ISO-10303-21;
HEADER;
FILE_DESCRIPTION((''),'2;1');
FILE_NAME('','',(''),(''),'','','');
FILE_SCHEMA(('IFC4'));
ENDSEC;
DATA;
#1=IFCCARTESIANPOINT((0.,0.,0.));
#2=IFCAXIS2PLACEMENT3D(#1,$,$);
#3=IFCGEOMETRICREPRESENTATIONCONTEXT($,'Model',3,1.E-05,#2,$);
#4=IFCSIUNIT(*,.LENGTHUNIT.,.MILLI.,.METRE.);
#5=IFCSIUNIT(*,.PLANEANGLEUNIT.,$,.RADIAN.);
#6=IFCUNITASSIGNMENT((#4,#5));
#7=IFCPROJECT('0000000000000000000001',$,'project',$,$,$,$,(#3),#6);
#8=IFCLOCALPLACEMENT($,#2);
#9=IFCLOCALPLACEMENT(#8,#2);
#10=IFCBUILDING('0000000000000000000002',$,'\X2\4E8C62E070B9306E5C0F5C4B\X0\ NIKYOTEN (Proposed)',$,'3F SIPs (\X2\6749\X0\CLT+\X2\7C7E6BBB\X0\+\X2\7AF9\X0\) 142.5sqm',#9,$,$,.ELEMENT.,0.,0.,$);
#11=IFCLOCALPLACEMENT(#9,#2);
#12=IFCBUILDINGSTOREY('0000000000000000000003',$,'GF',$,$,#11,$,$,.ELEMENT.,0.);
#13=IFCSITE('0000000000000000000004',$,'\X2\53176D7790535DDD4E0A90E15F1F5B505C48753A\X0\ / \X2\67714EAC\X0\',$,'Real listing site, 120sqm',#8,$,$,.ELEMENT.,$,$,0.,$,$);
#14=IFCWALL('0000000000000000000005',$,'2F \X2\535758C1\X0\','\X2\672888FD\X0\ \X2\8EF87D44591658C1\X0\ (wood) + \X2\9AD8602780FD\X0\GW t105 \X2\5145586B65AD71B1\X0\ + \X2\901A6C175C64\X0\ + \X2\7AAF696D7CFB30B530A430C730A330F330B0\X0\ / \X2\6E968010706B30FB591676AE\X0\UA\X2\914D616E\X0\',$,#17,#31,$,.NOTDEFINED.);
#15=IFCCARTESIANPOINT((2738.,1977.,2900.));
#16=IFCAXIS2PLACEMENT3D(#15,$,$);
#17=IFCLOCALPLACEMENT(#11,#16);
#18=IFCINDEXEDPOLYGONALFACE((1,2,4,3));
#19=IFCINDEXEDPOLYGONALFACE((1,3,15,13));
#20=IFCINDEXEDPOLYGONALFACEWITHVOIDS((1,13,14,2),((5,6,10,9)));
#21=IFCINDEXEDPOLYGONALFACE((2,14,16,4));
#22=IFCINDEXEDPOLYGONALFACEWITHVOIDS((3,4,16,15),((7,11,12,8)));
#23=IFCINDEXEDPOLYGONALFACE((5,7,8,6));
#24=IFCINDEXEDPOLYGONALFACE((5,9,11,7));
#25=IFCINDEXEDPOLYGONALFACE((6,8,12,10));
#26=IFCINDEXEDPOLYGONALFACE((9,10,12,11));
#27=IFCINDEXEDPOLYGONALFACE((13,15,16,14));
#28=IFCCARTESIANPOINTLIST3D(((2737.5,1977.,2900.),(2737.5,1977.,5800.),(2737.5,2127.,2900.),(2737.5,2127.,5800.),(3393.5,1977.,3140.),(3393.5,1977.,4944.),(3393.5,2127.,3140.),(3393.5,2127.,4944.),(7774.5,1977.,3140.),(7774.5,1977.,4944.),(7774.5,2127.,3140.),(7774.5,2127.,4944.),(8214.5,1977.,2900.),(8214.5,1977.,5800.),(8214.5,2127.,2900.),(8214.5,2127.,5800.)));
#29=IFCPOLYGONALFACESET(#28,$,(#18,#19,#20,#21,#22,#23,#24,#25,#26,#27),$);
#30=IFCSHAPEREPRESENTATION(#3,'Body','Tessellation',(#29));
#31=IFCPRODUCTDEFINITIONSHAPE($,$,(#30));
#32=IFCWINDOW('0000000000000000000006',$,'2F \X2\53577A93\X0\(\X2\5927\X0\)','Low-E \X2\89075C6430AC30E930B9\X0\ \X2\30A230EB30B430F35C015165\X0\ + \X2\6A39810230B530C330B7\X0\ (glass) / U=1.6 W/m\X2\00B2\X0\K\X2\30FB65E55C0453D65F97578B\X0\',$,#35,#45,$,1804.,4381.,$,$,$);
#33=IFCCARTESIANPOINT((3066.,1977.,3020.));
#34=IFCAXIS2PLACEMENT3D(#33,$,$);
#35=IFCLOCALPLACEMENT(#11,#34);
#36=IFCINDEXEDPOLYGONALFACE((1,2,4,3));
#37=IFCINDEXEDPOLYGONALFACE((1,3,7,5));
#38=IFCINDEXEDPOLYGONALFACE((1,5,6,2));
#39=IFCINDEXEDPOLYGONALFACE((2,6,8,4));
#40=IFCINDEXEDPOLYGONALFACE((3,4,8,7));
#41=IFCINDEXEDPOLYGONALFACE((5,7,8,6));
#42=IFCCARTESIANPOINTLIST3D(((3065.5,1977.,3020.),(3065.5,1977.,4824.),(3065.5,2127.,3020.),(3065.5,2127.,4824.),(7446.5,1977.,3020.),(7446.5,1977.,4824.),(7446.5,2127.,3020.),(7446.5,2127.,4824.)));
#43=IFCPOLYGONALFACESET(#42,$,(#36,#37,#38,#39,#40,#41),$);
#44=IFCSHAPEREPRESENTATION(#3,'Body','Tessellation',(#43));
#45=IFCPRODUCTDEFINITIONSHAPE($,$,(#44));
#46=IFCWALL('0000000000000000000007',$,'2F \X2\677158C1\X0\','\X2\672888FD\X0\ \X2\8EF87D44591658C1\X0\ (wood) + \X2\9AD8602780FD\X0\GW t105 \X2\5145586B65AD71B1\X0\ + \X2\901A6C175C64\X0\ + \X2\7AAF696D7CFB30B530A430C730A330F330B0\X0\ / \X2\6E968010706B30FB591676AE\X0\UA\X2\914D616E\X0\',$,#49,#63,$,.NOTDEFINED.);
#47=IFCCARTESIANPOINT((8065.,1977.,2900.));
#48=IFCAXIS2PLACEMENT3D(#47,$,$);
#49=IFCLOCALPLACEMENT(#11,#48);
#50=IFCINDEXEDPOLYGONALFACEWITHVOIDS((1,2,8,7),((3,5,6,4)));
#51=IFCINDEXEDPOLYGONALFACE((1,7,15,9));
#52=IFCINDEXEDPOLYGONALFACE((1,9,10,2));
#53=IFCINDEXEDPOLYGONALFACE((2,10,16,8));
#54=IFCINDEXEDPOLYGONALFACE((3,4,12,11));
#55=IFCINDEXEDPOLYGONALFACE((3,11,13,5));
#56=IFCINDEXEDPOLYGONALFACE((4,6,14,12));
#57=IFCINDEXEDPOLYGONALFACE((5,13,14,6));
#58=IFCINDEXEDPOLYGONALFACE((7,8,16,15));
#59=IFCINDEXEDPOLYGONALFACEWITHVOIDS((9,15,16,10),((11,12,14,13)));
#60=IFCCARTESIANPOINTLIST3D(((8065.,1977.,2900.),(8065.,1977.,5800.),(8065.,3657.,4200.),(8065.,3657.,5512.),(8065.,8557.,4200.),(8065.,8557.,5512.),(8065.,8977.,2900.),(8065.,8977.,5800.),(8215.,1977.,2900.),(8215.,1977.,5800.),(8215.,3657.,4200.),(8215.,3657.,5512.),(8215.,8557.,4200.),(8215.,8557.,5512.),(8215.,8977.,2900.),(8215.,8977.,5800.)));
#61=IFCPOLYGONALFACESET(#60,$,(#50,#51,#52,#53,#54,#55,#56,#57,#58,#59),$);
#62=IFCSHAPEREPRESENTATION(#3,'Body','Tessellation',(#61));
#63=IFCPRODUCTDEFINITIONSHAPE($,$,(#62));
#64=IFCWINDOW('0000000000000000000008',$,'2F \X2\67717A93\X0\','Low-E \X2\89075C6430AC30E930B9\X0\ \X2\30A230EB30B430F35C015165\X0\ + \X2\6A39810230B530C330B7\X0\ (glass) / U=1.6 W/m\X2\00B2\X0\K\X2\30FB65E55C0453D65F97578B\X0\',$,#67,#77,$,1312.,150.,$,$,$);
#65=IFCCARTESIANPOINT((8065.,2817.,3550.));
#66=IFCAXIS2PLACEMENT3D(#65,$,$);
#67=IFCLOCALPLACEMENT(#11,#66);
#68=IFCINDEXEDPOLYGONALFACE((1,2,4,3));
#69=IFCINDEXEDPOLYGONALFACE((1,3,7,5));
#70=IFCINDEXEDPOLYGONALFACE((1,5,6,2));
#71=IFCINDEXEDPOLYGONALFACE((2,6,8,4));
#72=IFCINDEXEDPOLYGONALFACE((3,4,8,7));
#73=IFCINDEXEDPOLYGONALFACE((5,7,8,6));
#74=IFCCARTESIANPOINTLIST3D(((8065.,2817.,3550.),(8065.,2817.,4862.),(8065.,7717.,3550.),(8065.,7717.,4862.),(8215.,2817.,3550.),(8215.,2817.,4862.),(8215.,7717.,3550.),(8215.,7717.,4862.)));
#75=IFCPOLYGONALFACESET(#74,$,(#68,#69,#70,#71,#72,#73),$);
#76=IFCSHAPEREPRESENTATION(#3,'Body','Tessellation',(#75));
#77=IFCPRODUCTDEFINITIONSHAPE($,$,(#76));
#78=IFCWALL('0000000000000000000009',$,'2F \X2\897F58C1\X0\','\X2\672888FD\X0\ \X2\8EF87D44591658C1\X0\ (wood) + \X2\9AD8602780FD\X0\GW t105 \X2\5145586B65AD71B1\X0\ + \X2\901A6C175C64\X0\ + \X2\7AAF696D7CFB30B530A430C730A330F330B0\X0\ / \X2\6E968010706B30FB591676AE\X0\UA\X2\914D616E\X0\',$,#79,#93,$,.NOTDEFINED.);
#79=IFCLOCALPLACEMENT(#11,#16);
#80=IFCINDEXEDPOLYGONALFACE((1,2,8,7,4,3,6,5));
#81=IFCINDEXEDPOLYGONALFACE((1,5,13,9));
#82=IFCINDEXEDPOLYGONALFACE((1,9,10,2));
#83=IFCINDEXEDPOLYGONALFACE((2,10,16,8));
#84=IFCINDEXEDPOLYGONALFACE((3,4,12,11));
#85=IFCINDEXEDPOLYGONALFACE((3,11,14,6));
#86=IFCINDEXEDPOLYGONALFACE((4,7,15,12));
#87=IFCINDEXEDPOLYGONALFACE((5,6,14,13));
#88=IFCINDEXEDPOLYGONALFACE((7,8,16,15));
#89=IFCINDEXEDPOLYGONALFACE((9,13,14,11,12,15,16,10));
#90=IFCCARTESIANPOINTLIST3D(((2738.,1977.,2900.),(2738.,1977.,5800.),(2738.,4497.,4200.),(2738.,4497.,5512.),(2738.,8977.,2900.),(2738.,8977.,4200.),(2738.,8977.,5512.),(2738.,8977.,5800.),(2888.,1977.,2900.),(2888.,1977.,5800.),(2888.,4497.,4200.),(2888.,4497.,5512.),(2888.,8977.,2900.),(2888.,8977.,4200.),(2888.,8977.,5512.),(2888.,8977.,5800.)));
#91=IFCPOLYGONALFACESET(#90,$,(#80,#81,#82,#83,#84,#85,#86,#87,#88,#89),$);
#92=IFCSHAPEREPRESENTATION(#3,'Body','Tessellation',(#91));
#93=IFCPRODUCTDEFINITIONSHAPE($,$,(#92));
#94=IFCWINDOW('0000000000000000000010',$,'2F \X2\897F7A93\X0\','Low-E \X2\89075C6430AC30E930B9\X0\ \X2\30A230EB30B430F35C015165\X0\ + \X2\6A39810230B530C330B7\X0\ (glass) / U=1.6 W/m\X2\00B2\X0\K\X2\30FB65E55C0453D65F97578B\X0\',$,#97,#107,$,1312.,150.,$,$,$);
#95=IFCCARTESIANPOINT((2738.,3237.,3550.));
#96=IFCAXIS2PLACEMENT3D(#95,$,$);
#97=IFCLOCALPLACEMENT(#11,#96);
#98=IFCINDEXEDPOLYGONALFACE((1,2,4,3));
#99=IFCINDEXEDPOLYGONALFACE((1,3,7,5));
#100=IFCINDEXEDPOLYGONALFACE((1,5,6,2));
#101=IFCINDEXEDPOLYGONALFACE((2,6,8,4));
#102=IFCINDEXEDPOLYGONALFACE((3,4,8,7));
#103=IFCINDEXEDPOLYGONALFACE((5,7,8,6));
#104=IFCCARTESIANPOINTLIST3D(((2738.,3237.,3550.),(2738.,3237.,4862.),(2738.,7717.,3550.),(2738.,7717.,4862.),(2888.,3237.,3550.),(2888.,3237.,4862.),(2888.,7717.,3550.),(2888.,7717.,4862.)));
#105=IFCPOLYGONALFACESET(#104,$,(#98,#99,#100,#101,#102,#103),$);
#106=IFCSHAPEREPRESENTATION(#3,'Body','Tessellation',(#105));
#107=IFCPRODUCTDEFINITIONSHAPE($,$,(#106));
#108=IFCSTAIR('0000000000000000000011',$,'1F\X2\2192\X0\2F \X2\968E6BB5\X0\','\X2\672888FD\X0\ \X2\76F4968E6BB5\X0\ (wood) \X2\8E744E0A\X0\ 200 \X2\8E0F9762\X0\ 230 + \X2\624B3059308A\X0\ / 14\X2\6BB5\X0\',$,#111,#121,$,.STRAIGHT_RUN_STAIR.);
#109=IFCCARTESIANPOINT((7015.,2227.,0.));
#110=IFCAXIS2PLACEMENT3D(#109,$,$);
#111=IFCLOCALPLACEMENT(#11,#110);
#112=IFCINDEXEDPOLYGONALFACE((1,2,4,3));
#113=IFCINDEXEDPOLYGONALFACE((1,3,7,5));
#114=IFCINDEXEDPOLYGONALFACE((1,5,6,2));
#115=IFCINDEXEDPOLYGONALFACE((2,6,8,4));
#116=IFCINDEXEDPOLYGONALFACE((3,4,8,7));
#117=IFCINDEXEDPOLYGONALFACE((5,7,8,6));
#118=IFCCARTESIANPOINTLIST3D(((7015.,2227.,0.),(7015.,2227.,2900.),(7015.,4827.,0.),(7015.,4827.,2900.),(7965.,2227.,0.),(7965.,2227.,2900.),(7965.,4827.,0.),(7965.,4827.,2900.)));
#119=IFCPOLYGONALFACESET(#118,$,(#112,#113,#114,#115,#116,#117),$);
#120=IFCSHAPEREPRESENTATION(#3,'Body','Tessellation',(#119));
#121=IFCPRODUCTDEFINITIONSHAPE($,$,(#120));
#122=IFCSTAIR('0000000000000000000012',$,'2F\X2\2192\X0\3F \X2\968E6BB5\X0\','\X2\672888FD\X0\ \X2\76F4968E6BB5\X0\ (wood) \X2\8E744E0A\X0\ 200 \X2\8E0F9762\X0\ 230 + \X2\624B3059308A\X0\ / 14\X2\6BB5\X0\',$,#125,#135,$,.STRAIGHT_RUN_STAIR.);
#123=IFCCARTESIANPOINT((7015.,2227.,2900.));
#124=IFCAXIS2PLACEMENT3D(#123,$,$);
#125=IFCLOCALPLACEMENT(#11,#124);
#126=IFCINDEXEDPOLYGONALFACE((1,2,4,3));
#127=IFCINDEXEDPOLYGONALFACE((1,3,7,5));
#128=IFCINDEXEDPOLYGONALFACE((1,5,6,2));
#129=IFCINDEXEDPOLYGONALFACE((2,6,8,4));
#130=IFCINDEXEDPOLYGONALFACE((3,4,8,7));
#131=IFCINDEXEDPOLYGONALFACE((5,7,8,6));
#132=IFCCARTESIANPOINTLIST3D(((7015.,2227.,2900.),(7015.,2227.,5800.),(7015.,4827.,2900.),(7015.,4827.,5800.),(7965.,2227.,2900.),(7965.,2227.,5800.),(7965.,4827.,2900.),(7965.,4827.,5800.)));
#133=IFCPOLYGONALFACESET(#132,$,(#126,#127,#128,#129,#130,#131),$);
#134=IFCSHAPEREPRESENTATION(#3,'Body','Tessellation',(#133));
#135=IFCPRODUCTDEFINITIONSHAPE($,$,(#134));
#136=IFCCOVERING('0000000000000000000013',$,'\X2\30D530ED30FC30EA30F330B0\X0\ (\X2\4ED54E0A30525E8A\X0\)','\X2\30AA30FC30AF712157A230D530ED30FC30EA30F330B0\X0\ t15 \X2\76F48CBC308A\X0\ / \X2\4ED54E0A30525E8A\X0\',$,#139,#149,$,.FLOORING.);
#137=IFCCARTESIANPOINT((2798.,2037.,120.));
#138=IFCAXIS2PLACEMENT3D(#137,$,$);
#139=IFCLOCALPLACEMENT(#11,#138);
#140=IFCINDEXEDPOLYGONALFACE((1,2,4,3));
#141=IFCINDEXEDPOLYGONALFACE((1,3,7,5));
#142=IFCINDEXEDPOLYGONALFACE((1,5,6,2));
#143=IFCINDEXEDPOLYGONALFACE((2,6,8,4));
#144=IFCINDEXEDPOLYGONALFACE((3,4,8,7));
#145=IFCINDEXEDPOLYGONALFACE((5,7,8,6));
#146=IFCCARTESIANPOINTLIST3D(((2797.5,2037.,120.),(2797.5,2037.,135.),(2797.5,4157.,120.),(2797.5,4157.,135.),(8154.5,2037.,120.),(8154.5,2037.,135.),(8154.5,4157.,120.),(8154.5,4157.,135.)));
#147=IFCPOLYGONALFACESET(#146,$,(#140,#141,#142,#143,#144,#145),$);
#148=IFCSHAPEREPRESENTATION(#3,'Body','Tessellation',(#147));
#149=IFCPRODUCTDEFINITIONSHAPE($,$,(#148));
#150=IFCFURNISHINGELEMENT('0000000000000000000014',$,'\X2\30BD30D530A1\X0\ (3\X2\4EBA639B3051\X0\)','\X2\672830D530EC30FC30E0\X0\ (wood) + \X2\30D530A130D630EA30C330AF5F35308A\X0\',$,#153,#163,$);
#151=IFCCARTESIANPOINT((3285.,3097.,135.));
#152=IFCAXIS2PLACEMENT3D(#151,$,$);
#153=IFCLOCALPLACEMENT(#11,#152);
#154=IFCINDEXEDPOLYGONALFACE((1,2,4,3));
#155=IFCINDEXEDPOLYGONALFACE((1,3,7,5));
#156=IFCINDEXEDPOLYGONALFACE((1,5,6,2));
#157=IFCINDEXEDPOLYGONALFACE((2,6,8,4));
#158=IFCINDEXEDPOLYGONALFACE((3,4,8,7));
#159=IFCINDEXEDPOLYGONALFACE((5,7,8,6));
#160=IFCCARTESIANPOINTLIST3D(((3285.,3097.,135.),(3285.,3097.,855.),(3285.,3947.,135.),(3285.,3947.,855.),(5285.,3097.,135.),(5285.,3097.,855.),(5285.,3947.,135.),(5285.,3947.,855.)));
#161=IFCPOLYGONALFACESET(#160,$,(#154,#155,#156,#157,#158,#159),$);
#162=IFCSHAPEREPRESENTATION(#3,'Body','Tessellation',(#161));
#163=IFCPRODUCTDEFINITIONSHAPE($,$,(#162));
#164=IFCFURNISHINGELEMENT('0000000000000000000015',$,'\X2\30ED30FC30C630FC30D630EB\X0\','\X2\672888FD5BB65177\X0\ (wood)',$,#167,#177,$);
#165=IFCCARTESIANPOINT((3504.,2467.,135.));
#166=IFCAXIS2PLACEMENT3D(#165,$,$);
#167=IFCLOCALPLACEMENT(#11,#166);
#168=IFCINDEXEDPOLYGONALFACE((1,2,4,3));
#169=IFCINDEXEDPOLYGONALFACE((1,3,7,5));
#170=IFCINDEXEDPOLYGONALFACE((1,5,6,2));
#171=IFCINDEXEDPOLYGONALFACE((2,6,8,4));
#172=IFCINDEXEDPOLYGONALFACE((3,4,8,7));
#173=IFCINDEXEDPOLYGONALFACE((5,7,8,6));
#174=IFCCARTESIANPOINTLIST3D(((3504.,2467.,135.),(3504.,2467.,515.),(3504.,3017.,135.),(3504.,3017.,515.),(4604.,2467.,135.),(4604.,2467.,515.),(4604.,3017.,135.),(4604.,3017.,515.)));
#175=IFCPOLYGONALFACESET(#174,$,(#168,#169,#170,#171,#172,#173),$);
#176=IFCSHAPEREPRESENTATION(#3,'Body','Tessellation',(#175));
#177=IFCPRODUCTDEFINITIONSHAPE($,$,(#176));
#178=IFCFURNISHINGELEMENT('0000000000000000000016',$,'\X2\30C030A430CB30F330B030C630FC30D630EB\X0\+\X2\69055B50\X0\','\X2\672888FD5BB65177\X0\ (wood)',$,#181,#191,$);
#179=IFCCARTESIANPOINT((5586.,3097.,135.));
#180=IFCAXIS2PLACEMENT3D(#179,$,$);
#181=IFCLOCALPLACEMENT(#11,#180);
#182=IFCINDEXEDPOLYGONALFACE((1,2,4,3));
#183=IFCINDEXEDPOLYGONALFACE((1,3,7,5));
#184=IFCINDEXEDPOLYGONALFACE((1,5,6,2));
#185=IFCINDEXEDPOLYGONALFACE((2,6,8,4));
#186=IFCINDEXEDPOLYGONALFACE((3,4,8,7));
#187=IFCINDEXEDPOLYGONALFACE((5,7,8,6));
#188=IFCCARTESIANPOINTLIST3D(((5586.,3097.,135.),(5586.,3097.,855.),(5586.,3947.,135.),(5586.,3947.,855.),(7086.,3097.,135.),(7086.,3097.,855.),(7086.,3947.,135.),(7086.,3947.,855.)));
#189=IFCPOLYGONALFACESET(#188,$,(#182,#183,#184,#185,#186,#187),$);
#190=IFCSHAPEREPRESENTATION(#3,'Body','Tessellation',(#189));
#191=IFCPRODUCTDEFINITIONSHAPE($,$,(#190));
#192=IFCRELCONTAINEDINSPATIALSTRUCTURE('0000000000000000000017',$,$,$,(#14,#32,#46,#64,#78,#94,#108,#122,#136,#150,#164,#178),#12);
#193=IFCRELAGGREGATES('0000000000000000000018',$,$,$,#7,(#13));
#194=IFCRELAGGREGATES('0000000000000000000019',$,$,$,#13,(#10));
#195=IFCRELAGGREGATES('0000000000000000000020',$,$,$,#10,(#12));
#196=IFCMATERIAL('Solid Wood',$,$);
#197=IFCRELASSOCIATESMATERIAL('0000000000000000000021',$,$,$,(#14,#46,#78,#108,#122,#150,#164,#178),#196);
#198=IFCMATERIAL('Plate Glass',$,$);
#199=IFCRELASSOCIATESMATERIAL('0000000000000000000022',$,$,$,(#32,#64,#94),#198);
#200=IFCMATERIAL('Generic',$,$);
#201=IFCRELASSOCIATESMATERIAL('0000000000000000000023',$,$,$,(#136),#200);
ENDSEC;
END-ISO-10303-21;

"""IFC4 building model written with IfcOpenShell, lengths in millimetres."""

from ifc_helpers import new_model, si_unit, frame, frame_2d, origin, place, context, project, spatial, rectangle, extrude, material, element, fill, save


model = new_model("IFC4")

# Units and contexts
model_context = context("Model", 3, precision=1e-05, world=origin())
ifc_project = project(units=[si_unit("LENGTHUNIT", "METRE", prefix="MILLI"), si_unit("PLANEANGLEUNIT", "RADIAN")], contexts=[model_context])

# Site, building, storey
site_placement = place(None, origin())
site = spatial("IfcSite", under=ifc_project, at=site_placement, Name="北海道川上郡弟子屈町 / 東京", ObjectType="Real listing site, 120sqm", CompositionType="ELEMENT", RefElevation=0.0)
building_placement = place(site_placement, origin())
building = spatial("IfcBuilding", under=site, at=building_placement, Name="二拠点の小屋 NIKYOTEN (Proposed)", ObjectType="3F SIPs (杉CLT+籾殻+竹) 142.5sqm", CompositionType="ELEMENT", ElevationOfRefHeight=0.0, ElevationOfTerrain=0.0)
storey_placement = place(building_placement, origin())
storey = spatial("IfcBuildingStorey", under=building, at=storey_placement, Name="GF", CompositionType="ELEMENT", Elevation=0.0)

# Shared definitions
ifc_material_1 = material(Name="Solid Wood")

# Shared definitions
ifc_material_2 = material(Name="Plate Glass")

# Walls, openings, windows
wall_1_placement = place(storey_placement, frame((2738.0, 1977.0, 2900.0)))
wall_1 = element("IfcWall", 1, at=wall_1_placement, inside=storey, material=ifc_material_1, Name="2F 南壁", Description="木製 軸組外壁 (wood) + 高性能GW t105 充填断熱 + 通気層 + 窯業系サイディング / 準耐火・外皮UA配慮", PredefinedType="NOTDEFINED", context=model_context, shape_type="SweptSolid", body=[
    extrude(rectangle(XDim=5477.0, YDim=150.0, at=frame_2d((2738.0, 75.0))), frame((2738.0, 1977.0, 2900.0)), (0.0, 0.0, 1.0), 2900.0),
])
opening_1_placement = place(storey_placement, frame((3066.0, 1977.0, 3020.0)))
opening_1 = element("IfcOpeningElement", 2, at=opening_1_placement, cuts=wall_1, PredefinedType="NOTDEFINED", context=model_context, shape_type="SweptSolid", body=[
    extrude(rectangle(XDim=4381.0, YDim=150.0, at=frame_2d((2190.0, 75.0))), frame((3066.0, 1977.0, 3020.0)), (0.0, 0.0, 1.0), 1804.0),
])
window_1_placement = place(storey_placement, frame((3066.0, 1977.0, 3020.0)))
window_1 = element("IfcWindow", 3, at=window_1_placement, inside=storey, material=ifc_material_2, Name="2F 南窓(大)", Description="Low-E 複層ガラス アルゴン封入 + 樹脂サッシ (glass) / U=1.6 W/m²K・日射取得型", OverallHeight=1804.0, OverallWidth=4381.0, context=model_context, shape_type="SweptSolid", body=[
    extrude(rectangle(XDim=4381.0, YDim=150.0, at=frame_2d((2190.0, 75.0))), frame((3066.0, 1977.0, 3020.0)), (0.0, 0.0, 1.0), 1804.0),
])
fill(opening_1, window_1)
wall_2_placement = place(storey_placement, frame((8065.0, 1977.0, 2900.0)))
wall_2 = element("IfcWall", 4, at=wall_2_placement, inside=storey, material=ifc_material_1, Name="2F 東壁", Description="木製 軸組外壁 (wood) + 高性能GW t105 充填断熱 + 通気層 + 窯業系サイディング / 準耐火・外皮UA配慮", PredefinedType="NOTDEFINED", context=model_context, shape_type="SweptSolid", body=[
    extrude(rectangle(XDim=150.0, YDim=7000.0, at=frame_2d((75.0, 3500.0))), frame((8065.0, 1977.0, 2900.0)), (0.0, 0.0, 1.0), 2900.0),
])
opening_2_placement = place(storey_placement, frame((8065.0, 2817.0, 3550.0)))
opening_2 = element("IfcOpeningElement", 5, at=opening_2_placement, cuts=wall_2, PredefinedType="NOTDEFINED", context=model_context, shape_type="SweptSolid", body=[
    extrude(rectangle(XDim=150.0, YDim=4900.0, at=frame_2d((75.0, 2450.0))), frame((8065.0, 2817.0, 3550.0)), (0.0, 0.0, 1.0), 1312.0),
])
window_2_placement = place(storey_placement, frame((8065.0, 2817.0, 3550.0)))
window_2 = element("IfcWindow", 6, at=window_2_placement, inside=storey, material=ifc_material_2, Name="2F 東窓", Description="Low-E 複層ガラス アルゴン封入 + 樹脂サッシ (glass) / U=1.6 W/m²K・日射取得型", OverallHeight=1312.0, OverallWidth=150.0, context=model_context, shape_type="SweptSolid", body=[
    extrude(rectangle(XDim=150.0, YDim=4900.0, at=frame_2d((75.0, 2450.0))), frame((8065.0, 2817.0, 3550.0)), (0.0, 0.0, 1.0), 1312.0),
])
fill(opening_2, window_2)
wall_3_placement = place(storey_placement, frame((2738.0, 1977.0, 2900.0)))
wall_3 = element("IfcWall", 7, at=wall_3_placement, inside=storey, material=ifc_material_1, Name="2F 西壁", Description="木製 軸組外壁 (wood) + 高性能GW t105 充填断熱 + 通気層 + 窯業系サイディング / 準耐火・外皮UA配慮", PredefinedType="NOTDEFINED", context=model_context, shape_type="SweptSolid", body=[
    extrude(rectangle(XDim=150.0, YDim=7000.0, at=frame_2d((75.0, 3500.0))), frame((2738.0, 1977.0, 2900.0)), (0.0, 0.0, 1.0), 2900.0),
])
opening_3_placement = place(storey_placement, frame((2738.0, 3237.0, 3550.0)))
opening_3 = element("IfcOpeningElement", 8, at=opening_3_placement, cuts=wall_3, PredefinedType="NOTDEFINED", context=model_context, shape_type="SweptSolid", body=[
    extrude(rectangle(XDim=150.0, YDim=4480.0, at=frame_2d((75.0, 2240.0))), frame((2738.0, 3237.0, 3550.0)), (0.0, 0.0, 1.0), 1312.0),
])
window_3_placement = place(storey_placement, frame((2738.0, 3237.0, 3550.0)))
window_3 = element("IfcWindow", 9, at=window_3_placement, inside=storey, material=ifc_material_2, Name="2F 西窓", Description="Low-E 複層ガラス アルゴン封入 + 樹脂サッシ (glass) / U=1.6 W/m²K・日射取得型", OverallHeight=1312.0, OverallWidth=150.0, context=model_context, shape_type="SweptSolid", body=[
    extrude(rectangle(XDim=150.0, YDim=4480.0, at=frame_2d((75.0, 2240.0))), frame((2738.0, 3237.0, 3550.0)), (0.0, 0.0, 1.0), 1312.0),
])
fill(opening_3, window_3)

# Stairs
stair_1_placement = place(storey_placement, frame((7015.0, 2227.0, 0.0)))
element("IfcStair", 10, at=stair_1_placement, inside=storey, material=ifc_material_1, Name="1F→2F 階段", Description="木製 直階段 (wood) 蹴上 200 踏面 230 + 手すり / 14段", PredefinedType="STRAIGHT_RUN_STAIR", context=model_context, shape_type="SweptSolid", body=[
    extrude(rectangle(XDim=950.0, YDim=2600.0, at=frame_2d((475.0, 1300.0))), frame((7015.0, 2227.0, 0.0)), (0.0, 0.0, 1.0), 2900.0),
])
stair_2_placement = place(storey_placement, frame((7015.0, 2227.0, 2900.0)))
element("IfcStair", 11, at=stair_2_placement, inside=storey, material=ifc_material_1, Name="2F→3F 階段", Description="木製 直階段 (wood) 蹴上 200 踏面 230 + 手すり / 14段", PredefinedType="STRAIGHT_RUN_STAIR", context=model_context, shape_type="SweptSolid", body=[
    extrude(rectangle(XDim=950.0, YDim=2600.0, at=frame_2d((475.0, 1300.0))), frame((7015.0, 2227.0, 2900.0)), (0.0, 0.0, 1.0), 2900.0),
])

# Covering
ifc_material_3 = material(Name="Generic")
covering_placement = place(storey_placement, frame((2798.0, 2037.0, 120.0)))
element("IfcCovering", 12, at=covering_placement, inside=storey, material=ifc_material_3, Name="フローリング (仕上げ床)", Description="オーク無垢フローリング t15 直貼り / 仕上げ床", PredefinedType="FLOORING", context=model_context, shape_type="SweptSolid", body=[
    extrude(rectangle(XDim=5357.0, YDim=2120.0, at=frame_2d((2678.0, 1060.0))), frame((2798.0, 2037.0, 120.0)), (0.0, 0.0, 1.0), 15.0),
])

# Furnishing elements
furnishing_1_placement = place(storey_placement, frame((3285.0, 3097.0, 135.0)))
element("IfcFurnishingElement", 13, at=furnishing_1_placement, inside=storey, material=ifc_material_1, Name="ソファ (3人掛け)", Description="木フレーム (wood) + ファブリック張り", context=model_context, shape_type="SweptSolid", body=[
    extrude(rectangle(XDim=2000.0, YDim=850.0, at=frame_2d((1000.0, 425.0))), frame((3285.0, 3097.0, 135.0)), (0.0, 0.0, 1.0), 720.0),
])
furnishing_2_placement = place(storey_placement, frame((3504.0, 2467.0, 135.0)))
element("IfcFurnishingElement", 14, at=furnishing_2_placement, inside=storey, material=ifc_material_1, Name="ローテーブル", Description="木製家具 (wood)", context=model_context, shape_type="SweptSolid", body=[
    extrude(rectangle(XDim=1100.0, YDim=550.0, at=frame_2d((550.0, 275.0))), frame((3504.0, 2467.0, 135.0)), (0.0, 0.0, 1.0), 380.0),
])
furnishing_3_placement = place(storey_placement, frame((5586.0, 3097.0, 135.0)))
element("IfcFurnishingElement", 15, at=furnishing_3_placement, inside=storey, material=ifc_material_1, Name="ダイニングテーブル+椅子", Description="木製家具 (wood)", context=model_context, shape_type="SweptSolid", body=[
    extrude(rectangle(XDim=1500.0, YDim=850.0, at=frame_2d((750.0, 425.0))), frame((5586.0, 3097.0, 135.0)), (0.0, 0.0, 1.0), 720.0),
])

save(model, "model.ifc")
